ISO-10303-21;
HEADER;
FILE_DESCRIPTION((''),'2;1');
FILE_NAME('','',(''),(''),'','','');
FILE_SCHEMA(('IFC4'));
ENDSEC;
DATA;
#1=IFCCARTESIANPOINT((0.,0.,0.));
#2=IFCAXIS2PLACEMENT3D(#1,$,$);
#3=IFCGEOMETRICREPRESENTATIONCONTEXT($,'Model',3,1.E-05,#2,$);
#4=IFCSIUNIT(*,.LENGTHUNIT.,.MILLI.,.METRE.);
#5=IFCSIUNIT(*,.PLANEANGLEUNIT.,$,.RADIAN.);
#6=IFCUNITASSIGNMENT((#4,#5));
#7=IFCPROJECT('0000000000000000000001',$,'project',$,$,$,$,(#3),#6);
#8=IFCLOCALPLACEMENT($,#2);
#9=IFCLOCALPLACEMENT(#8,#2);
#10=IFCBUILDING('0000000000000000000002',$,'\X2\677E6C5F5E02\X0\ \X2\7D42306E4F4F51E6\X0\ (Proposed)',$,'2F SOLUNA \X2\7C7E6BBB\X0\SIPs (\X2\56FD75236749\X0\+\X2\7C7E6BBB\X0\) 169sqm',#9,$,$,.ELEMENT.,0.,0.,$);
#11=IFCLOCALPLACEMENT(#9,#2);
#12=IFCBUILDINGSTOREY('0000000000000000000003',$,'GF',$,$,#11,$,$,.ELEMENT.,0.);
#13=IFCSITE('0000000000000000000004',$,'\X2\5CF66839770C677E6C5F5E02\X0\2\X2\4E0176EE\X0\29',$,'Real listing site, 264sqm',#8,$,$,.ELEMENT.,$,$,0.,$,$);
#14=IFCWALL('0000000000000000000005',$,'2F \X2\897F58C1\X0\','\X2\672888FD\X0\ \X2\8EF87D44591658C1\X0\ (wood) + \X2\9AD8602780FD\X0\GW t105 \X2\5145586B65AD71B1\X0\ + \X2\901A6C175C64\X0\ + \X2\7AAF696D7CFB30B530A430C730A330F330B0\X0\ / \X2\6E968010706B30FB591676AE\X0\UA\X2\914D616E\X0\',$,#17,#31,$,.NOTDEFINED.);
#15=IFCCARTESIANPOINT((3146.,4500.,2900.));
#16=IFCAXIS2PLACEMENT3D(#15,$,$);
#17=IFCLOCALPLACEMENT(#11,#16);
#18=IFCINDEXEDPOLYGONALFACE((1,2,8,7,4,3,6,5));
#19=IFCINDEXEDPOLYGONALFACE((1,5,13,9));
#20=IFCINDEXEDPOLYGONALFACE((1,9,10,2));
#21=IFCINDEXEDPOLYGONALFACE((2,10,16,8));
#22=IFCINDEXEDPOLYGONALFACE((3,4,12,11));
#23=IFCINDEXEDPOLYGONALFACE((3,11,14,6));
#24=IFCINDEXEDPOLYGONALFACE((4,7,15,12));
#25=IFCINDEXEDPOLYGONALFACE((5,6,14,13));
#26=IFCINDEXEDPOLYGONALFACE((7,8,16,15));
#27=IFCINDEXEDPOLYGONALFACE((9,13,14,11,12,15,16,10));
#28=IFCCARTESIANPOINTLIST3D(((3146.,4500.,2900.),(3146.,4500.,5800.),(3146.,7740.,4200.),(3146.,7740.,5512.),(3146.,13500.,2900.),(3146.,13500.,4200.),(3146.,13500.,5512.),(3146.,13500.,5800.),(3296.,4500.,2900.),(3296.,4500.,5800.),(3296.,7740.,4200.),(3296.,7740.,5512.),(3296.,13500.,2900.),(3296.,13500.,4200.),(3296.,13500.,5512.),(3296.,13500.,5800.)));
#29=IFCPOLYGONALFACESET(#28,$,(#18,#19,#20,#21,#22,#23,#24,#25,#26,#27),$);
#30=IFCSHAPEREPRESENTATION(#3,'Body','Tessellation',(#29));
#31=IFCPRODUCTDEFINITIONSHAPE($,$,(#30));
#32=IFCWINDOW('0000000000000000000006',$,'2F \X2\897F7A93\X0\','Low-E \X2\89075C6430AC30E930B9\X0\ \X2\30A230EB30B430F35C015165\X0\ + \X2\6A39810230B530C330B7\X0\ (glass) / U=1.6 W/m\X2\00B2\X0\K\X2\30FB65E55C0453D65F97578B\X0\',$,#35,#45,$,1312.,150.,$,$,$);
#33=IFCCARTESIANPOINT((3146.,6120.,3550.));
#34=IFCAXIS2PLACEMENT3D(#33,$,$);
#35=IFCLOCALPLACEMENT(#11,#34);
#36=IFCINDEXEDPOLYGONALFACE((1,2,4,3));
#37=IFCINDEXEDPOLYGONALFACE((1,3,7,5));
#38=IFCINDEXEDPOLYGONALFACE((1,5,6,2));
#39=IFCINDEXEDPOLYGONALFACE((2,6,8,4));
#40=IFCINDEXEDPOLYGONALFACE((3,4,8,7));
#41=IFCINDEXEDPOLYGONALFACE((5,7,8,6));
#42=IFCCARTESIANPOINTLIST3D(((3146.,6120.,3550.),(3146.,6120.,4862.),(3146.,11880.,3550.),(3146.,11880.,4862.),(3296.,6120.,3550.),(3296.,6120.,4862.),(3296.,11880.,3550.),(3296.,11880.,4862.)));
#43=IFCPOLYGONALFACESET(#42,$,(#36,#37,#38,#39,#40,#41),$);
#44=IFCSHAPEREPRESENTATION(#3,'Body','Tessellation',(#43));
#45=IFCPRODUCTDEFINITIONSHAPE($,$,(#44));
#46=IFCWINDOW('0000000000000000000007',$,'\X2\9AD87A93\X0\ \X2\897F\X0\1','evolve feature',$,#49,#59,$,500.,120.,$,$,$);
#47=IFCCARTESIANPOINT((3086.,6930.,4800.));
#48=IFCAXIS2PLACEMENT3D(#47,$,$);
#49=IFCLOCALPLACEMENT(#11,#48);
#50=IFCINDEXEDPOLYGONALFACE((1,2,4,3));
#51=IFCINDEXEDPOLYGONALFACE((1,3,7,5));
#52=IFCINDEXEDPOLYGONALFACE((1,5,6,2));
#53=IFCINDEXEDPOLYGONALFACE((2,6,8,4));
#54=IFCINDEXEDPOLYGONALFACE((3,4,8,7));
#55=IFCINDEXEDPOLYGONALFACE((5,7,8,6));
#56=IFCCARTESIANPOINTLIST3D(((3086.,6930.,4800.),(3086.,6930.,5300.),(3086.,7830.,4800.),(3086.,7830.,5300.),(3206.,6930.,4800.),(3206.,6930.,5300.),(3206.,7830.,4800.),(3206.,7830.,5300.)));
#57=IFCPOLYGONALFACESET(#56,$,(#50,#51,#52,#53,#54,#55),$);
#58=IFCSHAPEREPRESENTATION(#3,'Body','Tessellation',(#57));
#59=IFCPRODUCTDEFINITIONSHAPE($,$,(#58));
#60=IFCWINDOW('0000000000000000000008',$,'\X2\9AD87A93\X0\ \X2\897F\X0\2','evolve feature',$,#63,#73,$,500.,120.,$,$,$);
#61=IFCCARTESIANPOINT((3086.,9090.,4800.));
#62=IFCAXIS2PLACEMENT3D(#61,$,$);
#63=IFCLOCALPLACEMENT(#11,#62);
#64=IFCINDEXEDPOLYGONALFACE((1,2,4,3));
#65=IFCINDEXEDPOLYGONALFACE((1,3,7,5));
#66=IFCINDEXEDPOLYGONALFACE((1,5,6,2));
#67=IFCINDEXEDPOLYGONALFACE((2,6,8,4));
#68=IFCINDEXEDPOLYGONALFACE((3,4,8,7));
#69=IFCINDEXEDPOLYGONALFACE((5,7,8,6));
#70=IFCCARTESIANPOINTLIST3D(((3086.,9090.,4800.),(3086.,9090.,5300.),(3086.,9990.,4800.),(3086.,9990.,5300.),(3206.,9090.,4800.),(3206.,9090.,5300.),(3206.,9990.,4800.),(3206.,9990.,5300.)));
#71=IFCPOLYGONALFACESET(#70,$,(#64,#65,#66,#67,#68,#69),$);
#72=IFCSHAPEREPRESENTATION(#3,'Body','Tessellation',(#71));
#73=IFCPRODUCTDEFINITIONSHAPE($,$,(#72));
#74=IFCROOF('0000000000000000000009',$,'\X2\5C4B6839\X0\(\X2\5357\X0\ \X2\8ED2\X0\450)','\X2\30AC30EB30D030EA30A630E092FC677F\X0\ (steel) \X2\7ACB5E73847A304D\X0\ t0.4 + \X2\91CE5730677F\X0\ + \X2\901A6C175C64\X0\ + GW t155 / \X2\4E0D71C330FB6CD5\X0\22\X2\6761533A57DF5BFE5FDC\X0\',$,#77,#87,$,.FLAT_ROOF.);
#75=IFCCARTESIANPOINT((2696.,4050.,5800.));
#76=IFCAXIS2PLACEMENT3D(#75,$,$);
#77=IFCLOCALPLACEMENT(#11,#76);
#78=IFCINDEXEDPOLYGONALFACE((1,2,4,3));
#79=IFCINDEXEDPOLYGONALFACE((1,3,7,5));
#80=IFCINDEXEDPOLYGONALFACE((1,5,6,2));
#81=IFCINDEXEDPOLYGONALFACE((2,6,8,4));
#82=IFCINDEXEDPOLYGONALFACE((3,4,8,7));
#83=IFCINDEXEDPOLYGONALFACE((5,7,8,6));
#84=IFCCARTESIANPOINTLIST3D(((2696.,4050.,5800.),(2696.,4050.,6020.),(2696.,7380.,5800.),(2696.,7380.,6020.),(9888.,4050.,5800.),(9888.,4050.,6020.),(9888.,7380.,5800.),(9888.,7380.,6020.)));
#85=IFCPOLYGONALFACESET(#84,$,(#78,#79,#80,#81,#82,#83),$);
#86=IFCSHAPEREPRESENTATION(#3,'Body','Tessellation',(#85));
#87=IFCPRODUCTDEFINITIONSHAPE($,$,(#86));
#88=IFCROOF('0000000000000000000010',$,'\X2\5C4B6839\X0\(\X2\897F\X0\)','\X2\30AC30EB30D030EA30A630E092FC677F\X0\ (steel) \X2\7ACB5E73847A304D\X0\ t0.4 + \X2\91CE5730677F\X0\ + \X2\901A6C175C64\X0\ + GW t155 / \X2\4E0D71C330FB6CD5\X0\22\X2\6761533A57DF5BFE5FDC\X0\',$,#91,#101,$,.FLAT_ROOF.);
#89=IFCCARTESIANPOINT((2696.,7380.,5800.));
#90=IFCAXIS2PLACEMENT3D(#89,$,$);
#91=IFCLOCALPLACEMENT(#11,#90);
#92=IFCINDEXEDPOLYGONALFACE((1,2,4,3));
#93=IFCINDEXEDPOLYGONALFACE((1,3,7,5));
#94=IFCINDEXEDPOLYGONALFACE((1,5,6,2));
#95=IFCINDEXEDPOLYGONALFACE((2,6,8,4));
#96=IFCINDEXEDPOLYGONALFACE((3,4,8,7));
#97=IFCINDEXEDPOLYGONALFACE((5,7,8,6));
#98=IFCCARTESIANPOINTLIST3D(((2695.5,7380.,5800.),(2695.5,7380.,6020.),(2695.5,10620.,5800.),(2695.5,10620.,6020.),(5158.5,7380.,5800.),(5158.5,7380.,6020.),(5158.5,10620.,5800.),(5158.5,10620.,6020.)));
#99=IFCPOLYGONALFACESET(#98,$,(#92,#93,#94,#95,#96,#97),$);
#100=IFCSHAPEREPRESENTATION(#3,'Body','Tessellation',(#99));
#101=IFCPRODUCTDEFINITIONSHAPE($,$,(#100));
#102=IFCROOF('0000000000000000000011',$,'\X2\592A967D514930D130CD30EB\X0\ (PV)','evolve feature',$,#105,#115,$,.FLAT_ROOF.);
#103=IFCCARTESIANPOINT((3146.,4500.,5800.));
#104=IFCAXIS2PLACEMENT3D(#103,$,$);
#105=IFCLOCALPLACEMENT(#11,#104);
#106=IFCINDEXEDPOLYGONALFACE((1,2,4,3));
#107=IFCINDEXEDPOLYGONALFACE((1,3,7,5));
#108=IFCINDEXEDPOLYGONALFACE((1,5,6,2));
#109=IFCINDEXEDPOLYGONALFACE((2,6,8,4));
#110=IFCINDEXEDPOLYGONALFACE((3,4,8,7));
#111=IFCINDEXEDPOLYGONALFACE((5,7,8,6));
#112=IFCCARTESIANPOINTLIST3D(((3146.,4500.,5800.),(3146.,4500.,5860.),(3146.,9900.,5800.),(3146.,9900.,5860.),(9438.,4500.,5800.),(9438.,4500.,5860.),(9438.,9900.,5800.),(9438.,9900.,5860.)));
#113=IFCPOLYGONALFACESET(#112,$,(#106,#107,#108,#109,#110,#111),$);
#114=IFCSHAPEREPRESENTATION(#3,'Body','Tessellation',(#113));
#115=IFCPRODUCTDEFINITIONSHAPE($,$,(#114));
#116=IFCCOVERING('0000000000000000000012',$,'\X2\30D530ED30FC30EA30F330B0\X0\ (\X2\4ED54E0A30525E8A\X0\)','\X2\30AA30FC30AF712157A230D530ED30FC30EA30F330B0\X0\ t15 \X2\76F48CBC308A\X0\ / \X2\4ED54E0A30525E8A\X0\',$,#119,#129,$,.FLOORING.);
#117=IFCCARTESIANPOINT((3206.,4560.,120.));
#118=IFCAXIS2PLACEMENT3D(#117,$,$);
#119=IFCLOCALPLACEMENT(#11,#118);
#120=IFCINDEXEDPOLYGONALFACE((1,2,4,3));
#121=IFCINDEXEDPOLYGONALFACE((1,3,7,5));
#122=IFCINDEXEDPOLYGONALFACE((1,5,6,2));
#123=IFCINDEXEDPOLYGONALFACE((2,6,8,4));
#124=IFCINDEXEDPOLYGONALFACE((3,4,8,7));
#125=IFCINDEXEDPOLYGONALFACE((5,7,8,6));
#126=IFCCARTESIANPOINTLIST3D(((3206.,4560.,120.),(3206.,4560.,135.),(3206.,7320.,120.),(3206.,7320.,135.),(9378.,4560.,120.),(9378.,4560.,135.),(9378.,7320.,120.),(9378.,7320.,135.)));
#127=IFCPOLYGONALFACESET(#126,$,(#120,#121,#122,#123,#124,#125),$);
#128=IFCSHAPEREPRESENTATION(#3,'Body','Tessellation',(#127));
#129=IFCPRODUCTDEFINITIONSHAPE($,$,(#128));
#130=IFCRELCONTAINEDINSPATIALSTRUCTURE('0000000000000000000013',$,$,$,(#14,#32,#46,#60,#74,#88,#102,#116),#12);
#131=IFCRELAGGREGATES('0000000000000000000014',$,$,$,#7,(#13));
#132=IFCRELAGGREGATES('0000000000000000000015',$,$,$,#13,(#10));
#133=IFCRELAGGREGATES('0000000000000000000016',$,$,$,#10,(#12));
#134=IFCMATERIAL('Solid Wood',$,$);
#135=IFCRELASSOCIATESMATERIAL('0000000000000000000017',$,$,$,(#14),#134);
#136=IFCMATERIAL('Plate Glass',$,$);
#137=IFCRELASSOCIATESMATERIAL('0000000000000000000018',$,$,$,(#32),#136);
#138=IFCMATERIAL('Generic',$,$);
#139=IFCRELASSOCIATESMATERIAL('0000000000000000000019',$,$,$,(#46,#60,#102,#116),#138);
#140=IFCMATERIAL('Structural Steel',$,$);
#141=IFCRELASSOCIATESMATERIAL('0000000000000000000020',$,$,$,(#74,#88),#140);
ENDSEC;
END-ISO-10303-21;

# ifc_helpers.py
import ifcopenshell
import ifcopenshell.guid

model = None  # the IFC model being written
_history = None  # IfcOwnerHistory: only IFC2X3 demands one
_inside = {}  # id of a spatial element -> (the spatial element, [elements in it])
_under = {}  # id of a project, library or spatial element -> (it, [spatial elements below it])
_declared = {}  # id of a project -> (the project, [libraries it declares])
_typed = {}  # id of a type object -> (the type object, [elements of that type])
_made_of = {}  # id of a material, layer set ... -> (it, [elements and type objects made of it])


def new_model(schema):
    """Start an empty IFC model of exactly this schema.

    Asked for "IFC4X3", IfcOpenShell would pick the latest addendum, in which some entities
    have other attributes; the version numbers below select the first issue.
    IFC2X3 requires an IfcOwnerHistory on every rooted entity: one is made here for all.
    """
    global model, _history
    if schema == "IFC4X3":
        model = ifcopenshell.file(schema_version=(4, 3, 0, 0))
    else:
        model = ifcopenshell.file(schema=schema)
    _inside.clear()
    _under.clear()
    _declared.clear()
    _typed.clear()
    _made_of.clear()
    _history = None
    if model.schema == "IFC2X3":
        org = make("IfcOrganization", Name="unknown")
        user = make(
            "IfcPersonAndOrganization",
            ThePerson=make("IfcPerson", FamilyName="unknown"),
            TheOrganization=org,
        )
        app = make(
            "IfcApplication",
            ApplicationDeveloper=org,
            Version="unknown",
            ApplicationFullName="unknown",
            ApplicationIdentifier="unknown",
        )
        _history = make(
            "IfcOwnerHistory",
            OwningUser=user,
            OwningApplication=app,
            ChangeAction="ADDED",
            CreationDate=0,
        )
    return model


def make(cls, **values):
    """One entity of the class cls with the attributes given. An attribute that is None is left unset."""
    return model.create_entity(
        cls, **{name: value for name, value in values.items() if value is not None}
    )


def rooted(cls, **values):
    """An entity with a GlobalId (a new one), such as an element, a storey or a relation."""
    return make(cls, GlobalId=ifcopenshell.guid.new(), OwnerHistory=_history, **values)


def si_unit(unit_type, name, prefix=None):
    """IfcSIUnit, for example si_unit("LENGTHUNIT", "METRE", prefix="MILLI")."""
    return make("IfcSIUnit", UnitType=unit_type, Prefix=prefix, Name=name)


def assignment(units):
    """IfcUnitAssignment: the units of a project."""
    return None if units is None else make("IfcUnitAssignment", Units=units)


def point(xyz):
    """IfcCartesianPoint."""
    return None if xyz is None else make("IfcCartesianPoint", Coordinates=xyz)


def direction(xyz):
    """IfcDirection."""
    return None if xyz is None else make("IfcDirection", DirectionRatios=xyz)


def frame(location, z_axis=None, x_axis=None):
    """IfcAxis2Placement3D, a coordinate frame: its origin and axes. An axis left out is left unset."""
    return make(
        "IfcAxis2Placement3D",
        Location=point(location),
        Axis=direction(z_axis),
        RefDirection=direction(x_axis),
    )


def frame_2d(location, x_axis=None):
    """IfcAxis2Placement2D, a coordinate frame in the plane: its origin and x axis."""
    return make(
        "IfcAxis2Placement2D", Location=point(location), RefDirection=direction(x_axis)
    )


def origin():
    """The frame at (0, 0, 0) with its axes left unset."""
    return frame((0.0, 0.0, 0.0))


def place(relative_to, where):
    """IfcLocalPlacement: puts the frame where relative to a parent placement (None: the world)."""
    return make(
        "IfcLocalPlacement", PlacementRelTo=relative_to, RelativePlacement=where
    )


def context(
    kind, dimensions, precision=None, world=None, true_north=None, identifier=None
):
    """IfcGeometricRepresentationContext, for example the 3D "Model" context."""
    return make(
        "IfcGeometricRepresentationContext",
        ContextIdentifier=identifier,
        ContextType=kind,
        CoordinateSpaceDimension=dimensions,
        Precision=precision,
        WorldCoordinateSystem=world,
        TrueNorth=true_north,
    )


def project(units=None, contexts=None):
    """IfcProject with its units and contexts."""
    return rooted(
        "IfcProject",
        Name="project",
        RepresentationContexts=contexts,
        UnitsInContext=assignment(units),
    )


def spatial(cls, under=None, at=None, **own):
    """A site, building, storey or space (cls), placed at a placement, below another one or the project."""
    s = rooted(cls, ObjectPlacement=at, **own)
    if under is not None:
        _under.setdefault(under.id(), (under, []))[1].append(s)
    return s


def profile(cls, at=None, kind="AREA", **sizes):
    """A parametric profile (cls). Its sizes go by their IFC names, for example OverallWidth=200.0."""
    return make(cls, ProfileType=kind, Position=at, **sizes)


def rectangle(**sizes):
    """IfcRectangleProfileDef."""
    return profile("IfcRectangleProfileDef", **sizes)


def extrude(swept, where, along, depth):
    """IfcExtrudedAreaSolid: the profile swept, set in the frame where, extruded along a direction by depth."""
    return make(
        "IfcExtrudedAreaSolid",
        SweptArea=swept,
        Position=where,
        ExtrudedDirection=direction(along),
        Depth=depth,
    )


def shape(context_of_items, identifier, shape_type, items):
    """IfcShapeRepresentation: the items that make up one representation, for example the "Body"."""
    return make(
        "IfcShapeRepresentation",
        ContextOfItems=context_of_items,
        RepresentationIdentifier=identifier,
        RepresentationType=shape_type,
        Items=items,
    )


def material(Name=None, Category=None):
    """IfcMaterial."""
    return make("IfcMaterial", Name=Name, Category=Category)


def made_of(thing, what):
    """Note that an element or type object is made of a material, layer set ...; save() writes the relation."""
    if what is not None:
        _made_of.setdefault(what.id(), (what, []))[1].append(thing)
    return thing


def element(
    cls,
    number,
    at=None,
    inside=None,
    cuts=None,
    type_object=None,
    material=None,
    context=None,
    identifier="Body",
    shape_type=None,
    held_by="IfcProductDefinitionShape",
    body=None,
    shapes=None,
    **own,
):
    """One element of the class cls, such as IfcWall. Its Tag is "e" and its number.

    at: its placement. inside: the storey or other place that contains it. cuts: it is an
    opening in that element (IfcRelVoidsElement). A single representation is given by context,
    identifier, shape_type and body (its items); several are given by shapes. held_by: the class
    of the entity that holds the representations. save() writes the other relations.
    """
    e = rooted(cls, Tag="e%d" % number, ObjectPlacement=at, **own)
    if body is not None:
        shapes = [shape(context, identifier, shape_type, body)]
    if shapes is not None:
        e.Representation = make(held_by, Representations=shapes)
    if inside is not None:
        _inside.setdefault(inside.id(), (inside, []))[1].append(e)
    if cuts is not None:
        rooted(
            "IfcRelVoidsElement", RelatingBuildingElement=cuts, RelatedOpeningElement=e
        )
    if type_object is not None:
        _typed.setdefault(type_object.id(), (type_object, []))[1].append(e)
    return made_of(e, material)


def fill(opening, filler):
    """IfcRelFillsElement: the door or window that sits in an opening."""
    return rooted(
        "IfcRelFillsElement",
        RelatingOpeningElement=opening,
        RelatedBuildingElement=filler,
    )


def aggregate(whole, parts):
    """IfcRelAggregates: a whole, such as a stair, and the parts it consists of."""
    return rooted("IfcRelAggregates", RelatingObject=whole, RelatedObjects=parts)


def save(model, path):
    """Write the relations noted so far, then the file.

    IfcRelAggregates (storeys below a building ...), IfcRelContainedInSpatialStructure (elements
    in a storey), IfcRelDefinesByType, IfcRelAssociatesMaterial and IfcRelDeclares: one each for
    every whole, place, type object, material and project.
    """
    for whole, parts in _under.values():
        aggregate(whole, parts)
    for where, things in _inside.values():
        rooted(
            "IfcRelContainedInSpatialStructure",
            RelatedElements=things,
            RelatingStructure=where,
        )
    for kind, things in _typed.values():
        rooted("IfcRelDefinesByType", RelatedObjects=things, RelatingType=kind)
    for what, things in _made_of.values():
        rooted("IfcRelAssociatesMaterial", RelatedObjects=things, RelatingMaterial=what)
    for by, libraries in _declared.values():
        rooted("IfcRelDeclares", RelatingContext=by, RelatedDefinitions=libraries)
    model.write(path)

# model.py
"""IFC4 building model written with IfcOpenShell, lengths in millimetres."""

from ifc_helpers import new_model, si_unit, frame, frame_2d, origin, place, context, project, spatial, rectangle, extrude, material, element, fill, save


model = new_model("IFC4")

# Units and contexts
model_context = context("Model", 3, precision=1e-05, world=origin())
ifc_project = project(units=[si_unit("LENGTHUNIT", "METRE", prefix="MILLI"), si_unit("PLANEANGLEUNIT", "RADIAN")], contexts=[model_context])

# Site, building, storey
site_placement = place(None, origin())
site = spatial("IfcSite", under=ifc_project, at=site_placement, Name="島根県松江市2丁目29", ObjectType="Real listing site, 264sqm", CompositionType="ELEMENT", RefElevation=0.0)
building_placement = place(site_placement, origin())
building = spatial("IfcBuilding", under=site, at=building_placement, Name="松江市 終の住処 (Proposed)", ObjectType="2F SOLUNA 籾殻SIPs (国産杉+籾殻) 169sqm", CompositionType="ELEMENT", ElevationOfRefHeight=0.0, ElevationOfTerrain=0.0)
storey_placement = place(building_placement, origin())
storey = spatial("IfcBuildingStorey", under=building, at=storey_placement, Name="GF", CompositionType="ELEMENT", Elevation=0.0)

# Shared definitions
ifc_material_1 = material(Name="Solid Wood")
ifc_material_2 = material(Name="Generic")

# Shared definitions
ifc_material_3 = material(Name="Plate Glass")

# Wall, openings, windows
wall_1_placement = place(storey_placement, frame((3146.0, 4500.0, 2900.0)))
wall_1 = element("IfcWall", 1, at=wall_1_placement, inside=storey, material=ifc_material_1, Name="2F 西壁", Description="木製 軸組外壁 (wood) + 高性能GW t105 充填断熱 + 通気層 + 窯業系サイディング / 準耐火・外皮UA配慮", PredefinedType="NOTDEFINED", context=model_context, shape_type="SweptSolid", body=[
    extrude(rectangle(XDim=150.0, YDim=9000.0, at=frame_2d((75.0, 4500.0))), frame((3146.0, 4500.0, 2900.0)), (0.0, 0.0, 1.0), 2900.0),
])
opening_1_placement = place(storey_placement, frame((3146.0, 6120.0, 3550.0)))
opening_1 = element("IfcOpeningElement", 2, at=opening_1_placement, cuts=wall_1, PredefinedType="NOTDEFINED", context=model_context, shape_type="SweptSolid", body=[
    extrude(rectangle(XDim=150.0, YDim=5760.0, at=frame_2d((75.0, 2880.0))), frame((3146.0, 6120.0, 3550.0)), (0.0, 0.0, 1.0), 1312.0),
])
opening_2_placement = place(storey_placement, frame((3086.0, 6930.0, 4800.0)))
opening_2 = element("IfcOpeningElement", 3, at=opening_2_placement, cuts=wall_1, PredefinedType="NOTDEFINED", context=model_context, shape_type="SweptSolid", body=[
    extrude(rectangle(XDim=120.0, YDim=900.0, at=frame_2d((60.0, 450.0))), frame((3086.0, 6930.0, 4800.0)), (0.0, 0.0, 1.0), 500.0),
])
opening_3_placement = place(storey_placement, frame((3086.0, 9090.0, 4800.0)))
opening_3 = element("IfcOpeningElement", 4, at=opening_3_placement, cuts=wall_1, PredefinedType="NOTDEFINED", context=model_context, shape_type="SweptSolid", body=[
    extrude(rectangle(XDim=120.0, YDim=900.0, at=frame_2d((60.0, 450.0))), frame((3086.0, 9090.0, 4800.0)), (0.0, 0.0, 1.0), 500.0),
])
window_1_placement = place(storey_placement, frame((3146.0, 6120.0, 3550.0)))
window_1 = element("IfcWindow", 5, at=window_1_placement, inside=storey, material=ifc_material_3, Name="2F 西窓", Description="Low-E 複層ガラス アルゴン封入 + 樹脂サッシ (glass) / U=1.6 W/m²K・日射取得型", OverallHeight=1312.0, OverallWidth=150.0, context=model_context, shape_type="SweptSolid", body=[
    extrude(rectangle(XDim=150.0, YDim=5760.0, at=frame_2d((75.0, 2880.0))), frame((3146.0, 6120.0, 3550.0)), (0.0, 0.0, 1.0), 1312.0),
])
fill(opening_1, window_1)
window_2_placement = place(storey_placement, frame((3086.0, 6930.0, 4800.0)))
window_2 = element("IfcWindow", 6, at=window_2_placement, inside=storey, material=ifc_material_2, Name="高窓 西1", Description="evolve feature", OverallHeight=500.0, OverallWidth=120.0, context=model_context, shape_type="SweptSolid", body=[
    extrude(rectangle(XDim=120.0, YDim=900.0, at=frame_2d((60.0, 450.0))), frame((3086.0, 6930.0, 4800.0)), (0.0, 0.0, 1.0), 500.0),
])
fill(opening_2, window_2)
window_3_placement = place(storey_placement, frame((3086.0, 9090.0, 4800.0)))
window_3 = element("IfcWindow", 7, at=window_3_placement, inside=storey, material=ifc_material_2, Name="高窓 西2", Description="evolve feature", OverallHeight=500.0, OverallWidth=120.0, context=model_context, shape_type="SweptSolid", body=[
    extrude(rectangle(XDim=120.0, YDim=900.0, at=frame_2d((60.0, 450.0))), frame((3086.0, 9090.0, 4800.0)), (0.0, 0.0, 1.0), 500.0),
])
fill(opening_3, window_3)

# Roofs
ifc_material_4 = material(Name="Structural Steel")
roof_1_placement = place(storey_placement, frame((2696.0, 4050.0, 5800.0)))
element("IfcRoof", 8, at=roof_1_placement, inside=storey, material=ifc_material_4, Name="屋根(南 軒450)", Description="ガルバリウム鋼板 (steel) 立平葺き t0.4 + 野地板 + 通気層 + GW t155 / 不燃・法22条区域対応", PredefinedType="FLAT_ROOF", context=model_context, shape_type="SweptSolid", body=[
    extrude(rectangle(XDim=7192.0, YDim=3330.0, at=frame_2d((3596.0, 1665.0))), frame((2696.0, 4050.0, 5800.0)), (0.0, 0.0, 1.0), 220.0),
])
roof_2_placement = place(storey_placement, frame((2696.0, 7380.0, 5800.0)))
element("IfcRoof", 9, at=roof_2_placement, inside=storey, material=ifc_material_4, Name="屋根(西)", Description="ガルバリウム鋼板 (steel) 立平葺き t0.4 + 野地板 + 通気層 + GW t155 / 不燃・法22条区域対応", PredefinedType="FLAT_ROOF", context=model_context, shape_type="SweptSolid", body=[
    extrude(rectangle(XDim=2463.0, YDim=3240.0, at=frame_2d((1231.0, 1620.0))), frame((2696.0, 7380.0, 5800.0)), (0.0, 0.0, 1.0), 220.0),
])
roof_3_placement = place(storey_placement, frame((3146.0, 4500.0, 5800.0)))
element("IfcRoof", 10, at=roof_3_placement, inside=storey, material=ifc_material_2, Name="太陽光パネル (PV)", Description="evolve feature", PredefinedType="FLAT_ROOF", context=model_context, shape_type="SweptSolid", body=[
    extrude(rectangle(XDim=6292.0, YDim=5400.0, at=frame_2d((3146.0, 2700.0))), frame((3146.0, 4500.0, 5800.0)), (0.0, 0.0, 1.0), 60.0),
])

# Covering
covering_placement = place(storey_placement, frame((3206.0, 4560.0, 120.0)))
element("IfcCovering", 11, at=covering_placement, inside=storey, material=ifc_material_2, Name="フローリング (仕上げ床)", Description="オーク無垢フローリング t15 直貼り / 仕上げ床", PredefinedType="FLOORING", context=model_context, shape_type="SweptSolid", body=[
    extrude(rectangle(XDim=6172.0, YDim=2760.0, at=frame_2d((3086.0, 1380.0))), frame((3206.0, 4560.0, 120.0)), (0.0, 0.0, 1.0), 15.0),
])

save(model, "model.ifc")
